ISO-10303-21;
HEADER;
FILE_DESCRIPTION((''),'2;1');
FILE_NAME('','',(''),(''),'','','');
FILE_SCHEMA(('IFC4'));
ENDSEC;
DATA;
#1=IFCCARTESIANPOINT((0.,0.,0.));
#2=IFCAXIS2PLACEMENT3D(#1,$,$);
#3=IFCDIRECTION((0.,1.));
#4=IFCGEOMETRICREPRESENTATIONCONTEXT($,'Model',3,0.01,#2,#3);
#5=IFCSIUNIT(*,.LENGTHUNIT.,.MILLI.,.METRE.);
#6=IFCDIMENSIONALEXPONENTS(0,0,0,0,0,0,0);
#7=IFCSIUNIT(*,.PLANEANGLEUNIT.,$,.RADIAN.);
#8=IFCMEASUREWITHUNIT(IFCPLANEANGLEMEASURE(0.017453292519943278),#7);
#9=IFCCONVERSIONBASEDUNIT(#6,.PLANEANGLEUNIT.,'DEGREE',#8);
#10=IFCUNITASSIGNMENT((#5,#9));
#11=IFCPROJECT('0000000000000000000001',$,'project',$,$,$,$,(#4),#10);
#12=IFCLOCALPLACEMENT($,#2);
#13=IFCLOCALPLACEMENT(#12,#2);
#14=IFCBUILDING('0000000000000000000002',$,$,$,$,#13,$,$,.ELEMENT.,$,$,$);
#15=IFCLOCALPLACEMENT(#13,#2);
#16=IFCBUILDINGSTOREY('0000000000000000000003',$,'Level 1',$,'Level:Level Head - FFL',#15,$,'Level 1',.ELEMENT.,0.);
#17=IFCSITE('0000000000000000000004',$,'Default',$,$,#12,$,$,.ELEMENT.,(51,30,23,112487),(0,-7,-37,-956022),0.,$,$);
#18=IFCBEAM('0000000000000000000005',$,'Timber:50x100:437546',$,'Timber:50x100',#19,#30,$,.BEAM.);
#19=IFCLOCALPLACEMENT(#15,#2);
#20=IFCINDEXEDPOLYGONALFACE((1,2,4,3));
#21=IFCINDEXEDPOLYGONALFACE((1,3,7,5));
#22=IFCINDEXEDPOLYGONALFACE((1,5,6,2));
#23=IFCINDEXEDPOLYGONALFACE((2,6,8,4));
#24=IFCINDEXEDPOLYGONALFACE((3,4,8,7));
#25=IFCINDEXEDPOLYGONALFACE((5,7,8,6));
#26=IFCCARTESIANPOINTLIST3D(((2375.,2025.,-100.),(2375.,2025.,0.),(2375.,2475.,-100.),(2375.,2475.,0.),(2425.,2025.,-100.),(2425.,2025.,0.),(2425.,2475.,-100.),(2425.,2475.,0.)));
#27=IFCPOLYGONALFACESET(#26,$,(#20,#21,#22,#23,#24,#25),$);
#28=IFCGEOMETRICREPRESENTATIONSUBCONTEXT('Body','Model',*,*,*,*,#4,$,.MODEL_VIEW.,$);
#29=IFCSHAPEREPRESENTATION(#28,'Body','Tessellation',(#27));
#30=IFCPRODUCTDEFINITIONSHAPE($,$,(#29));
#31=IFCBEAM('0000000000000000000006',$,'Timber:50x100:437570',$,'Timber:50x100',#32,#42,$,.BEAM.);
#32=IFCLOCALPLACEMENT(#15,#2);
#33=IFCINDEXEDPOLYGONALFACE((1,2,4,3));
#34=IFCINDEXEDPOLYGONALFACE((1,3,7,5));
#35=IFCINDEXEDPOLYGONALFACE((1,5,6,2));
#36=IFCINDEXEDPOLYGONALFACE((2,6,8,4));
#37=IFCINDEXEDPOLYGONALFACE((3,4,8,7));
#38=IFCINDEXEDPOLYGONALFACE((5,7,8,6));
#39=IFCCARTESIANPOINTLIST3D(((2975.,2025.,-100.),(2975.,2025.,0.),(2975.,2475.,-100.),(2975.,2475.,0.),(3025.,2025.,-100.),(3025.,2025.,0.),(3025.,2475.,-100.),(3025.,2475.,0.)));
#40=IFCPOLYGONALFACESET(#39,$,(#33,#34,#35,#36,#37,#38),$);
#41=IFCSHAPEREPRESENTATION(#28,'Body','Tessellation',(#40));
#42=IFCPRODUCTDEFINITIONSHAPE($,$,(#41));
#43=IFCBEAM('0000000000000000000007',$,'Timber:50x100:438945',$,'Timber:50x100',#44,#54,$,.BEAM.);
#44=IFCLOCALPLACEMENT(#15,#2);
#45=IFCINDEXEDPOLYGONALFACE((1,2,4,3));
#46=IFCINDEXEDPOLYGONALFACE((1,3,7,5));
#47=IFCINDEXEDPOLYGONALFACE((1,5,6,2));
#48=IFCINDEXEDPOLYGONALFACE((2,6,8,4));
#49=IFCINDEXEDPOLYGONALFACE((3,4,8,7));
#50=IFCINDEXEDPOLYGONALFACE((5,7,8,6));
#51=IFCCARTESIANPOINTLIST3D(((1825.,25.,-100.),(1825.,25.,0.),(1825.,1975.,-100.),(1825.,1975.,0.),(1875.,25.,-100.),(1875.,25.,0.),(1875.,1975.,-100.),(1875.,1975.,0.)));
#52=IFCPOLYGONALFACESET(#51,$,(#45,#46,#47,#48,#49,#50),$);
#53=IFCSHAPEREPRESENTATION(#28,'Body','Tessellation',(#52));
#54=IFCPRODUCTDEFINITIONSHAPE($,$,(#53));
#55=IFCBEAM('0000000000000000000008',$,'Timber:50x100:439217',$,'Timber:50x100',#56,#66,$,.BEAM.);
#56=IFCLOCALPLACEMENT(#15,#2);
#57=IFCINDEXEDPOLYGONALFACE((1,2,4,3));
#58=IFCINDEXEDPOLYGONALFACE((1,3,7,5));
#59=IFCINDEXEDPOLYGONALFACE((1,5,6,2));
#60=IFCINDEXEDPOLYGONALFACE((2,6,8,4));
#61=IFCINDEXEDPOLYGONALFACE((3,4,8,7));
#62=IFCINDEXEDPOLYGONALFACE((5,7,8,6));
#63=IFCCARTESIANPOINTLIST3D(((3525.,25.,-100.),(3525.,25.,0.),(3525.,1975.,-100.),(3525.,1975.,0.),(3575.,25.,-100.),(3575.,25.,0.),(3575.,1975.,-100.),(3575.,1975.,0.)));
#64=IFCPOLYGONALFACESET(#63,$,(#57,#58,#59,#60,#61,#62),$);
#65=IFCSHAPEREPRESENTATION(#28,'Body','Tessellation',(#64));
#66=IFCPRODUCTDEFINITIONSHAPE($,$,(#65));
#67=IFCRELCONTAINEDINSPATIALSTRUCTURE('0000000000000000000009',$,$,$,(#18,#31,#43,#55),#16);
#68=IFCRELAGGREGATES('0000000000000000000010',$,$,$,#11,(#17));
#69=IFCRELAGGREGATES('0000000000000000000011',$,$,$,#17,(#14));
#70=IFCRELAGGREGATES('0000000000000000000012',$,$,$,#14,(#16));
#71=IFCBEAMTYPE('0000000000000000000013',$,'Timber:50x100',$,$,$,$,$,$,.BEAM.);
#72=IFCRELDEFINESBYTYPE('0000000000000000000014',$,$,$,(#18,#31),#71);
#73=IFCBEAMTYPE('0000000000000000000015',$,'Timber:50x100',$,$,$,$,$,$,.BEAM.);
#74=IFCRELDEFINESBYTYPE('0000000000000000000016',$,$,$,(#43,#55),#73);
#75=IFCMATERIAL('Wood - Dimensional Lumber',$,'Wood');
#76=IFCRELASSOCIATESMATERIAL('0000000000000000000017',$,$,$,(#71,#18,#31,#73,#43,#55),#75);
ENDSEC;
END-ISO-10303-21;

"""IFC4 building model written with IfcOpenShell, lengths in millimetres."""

from ifc_helpers import new_model, entity, si_unit, converted_unit, direction, frame, origin, place, context, subcontext, project, spatial, indexed_curve, outline, extrude, source, transform, mapped, material, type_object, type_shapes, element, save


model = new_model("IFC4")

# Units and contexts
model_context = context("Model", 3, precision=0.01, world=origin(), true_north=direction((0.0, 1.0)))
body_context = subcontext(model_context, "Body", "Model", "MODEL_VIEW")
ifc_project = project(units=[si_unit("LENGTHUNIT", "METRE", prefix="MILLI"), converted_unit("PLANEANGLEUNIT", "DEGREE", entity("IfcPlaneAngleMeasure", 0.017453292519943278), si_unit("PLANEANGLEUNIT", "RADIAN"), dimensions=[0, 0, 0, 0, 0, 0, 0])], contexts=[model_context])

# Site, building, storey
site_placement = place(None, origin())
site = spatial("IfcSite", under=ifc_project, at=site_placement, Name="Default", CompositionType="ELEMENT", RefLatitude=(51, 30, 23, 112487), RefLongitude=(0, -7, -37, -956022), RefElevation=0.0)
building_placement = place(site_placement, origin())
building = spatial("IfcBuilding", under=site, at=building_placement, CompositionType="ELEMENT")
storey_placement = place(building_placement, origin())
storey = spatial("IfcBuildingStorey", under=building, at=storey_placement, Name="Level 1", ObjectType="Level:Level Head - FFL", LongName="Level 1", CompositionType="ELEMENT", Elevation=0.0)

# Beams
ifc_material = material(Name="Wood - Dimensional Lumber", Category="Wood")
beam_type_1 = type_object("IfcBeamType", Name="Timber:50x100", PredefinedType="BEAM", material=ifc_material)
shared_shape_1 = source(origin(), body_context, "Body", "SweptSolid", [
    extrude(outline(indexed_curve([(-225.0, -25.0), (225.0, -25.0), (225.0, 25.0), (-225.0, 25.0), (-225.0, -25.0)], self_intersect=False)), frame((0.0, 0.0, -50.0), z_axis=(0.0, 0.0, 1.0), x_axis=(-1.0, 0.0, 0.0)), (0.0, 0.0, 1.0), 100.0),
])
type_shapes(beam_type_1, [shared_shape_1])
for number, where, z_axis, x_axis, name in (
    (1, (2400.0, 2250.0, -50.0), (0.0, 0.0, 1.0), (0.0, -1.0, 0.0), "Timber:50x100:437546"),
    (2, (3000.0, 2250.0, -50.0), (0.0, 0.0, 1.0), (0.0, -1.0, 0.0), "Timber:50x100:437570"),
):
    element("IfcBeam", number, at=place(storey_placement, frame(where, z_axis=z_axis, x_axis=x_axis)), inside=storey, type_object=beam_type_1, material=ifc_material, Name=name, ObjectType="Timber:50x100", PredefinedType="BEAM", context=body_context, shape_type="MappedRepresentation", body=[
        mapped(shared_shape_1, transform((0.0, 0.0, 0.0), scale=1.0)),
    ])
beam_type_2 = type_object("IfcBeamType", Name="Timber:50x100", PredefinedType="BEAM", material=ifc_material)
shared_shape_2 = source(origin(), body_context, "Body", "SweptSolid", [
    extrude(outline(indexed_curve([(-975.0, -25.0), (975.0, -25.0), (975.0, 25.0), (-975.0, 25.0), (-975.0, -25.0)], self_intersect=False)), frame((0.0, 0.0, -50.0), z_axis=(0.0, 0.0, 1.0), x_axis=(-1.0, 0.0, 0.0)), (0.0, 0.0, 1.0), 100.0),
])
type_shapes(beam_type_2, [shared_shape_2])
for number, where, z_axis, x_axis, name in (
    (3, (1850.0, 1000.0, -50.0), (0.0, 0.0, 1.0), (0.0, 1.0, 0.0), "Timber:50x100:438945"),
    (4, (3550.0, 1000.0, -50.0), (0.0, 0.0, 1.0), (0.0, 1.0, 0.0), "Timber:50x100:439217"),
):
    element("IfcBeam", number, at=place(storey_placement, frame(where, z_axis=z_axis, x_axis=x_axis)), inside=storey, type_object=beam_type_2, material=ifc_material, Name=name, ObjectType="Timber:50x100", PredefinedType="BEAM", context=body_context, shape_type="MappedRepresentation", body=[
        mapped(shared_shape_2, transform((0.0, 0.0, 0.0), scale=1.0)),
    ])

save(model, "model.ifc")
